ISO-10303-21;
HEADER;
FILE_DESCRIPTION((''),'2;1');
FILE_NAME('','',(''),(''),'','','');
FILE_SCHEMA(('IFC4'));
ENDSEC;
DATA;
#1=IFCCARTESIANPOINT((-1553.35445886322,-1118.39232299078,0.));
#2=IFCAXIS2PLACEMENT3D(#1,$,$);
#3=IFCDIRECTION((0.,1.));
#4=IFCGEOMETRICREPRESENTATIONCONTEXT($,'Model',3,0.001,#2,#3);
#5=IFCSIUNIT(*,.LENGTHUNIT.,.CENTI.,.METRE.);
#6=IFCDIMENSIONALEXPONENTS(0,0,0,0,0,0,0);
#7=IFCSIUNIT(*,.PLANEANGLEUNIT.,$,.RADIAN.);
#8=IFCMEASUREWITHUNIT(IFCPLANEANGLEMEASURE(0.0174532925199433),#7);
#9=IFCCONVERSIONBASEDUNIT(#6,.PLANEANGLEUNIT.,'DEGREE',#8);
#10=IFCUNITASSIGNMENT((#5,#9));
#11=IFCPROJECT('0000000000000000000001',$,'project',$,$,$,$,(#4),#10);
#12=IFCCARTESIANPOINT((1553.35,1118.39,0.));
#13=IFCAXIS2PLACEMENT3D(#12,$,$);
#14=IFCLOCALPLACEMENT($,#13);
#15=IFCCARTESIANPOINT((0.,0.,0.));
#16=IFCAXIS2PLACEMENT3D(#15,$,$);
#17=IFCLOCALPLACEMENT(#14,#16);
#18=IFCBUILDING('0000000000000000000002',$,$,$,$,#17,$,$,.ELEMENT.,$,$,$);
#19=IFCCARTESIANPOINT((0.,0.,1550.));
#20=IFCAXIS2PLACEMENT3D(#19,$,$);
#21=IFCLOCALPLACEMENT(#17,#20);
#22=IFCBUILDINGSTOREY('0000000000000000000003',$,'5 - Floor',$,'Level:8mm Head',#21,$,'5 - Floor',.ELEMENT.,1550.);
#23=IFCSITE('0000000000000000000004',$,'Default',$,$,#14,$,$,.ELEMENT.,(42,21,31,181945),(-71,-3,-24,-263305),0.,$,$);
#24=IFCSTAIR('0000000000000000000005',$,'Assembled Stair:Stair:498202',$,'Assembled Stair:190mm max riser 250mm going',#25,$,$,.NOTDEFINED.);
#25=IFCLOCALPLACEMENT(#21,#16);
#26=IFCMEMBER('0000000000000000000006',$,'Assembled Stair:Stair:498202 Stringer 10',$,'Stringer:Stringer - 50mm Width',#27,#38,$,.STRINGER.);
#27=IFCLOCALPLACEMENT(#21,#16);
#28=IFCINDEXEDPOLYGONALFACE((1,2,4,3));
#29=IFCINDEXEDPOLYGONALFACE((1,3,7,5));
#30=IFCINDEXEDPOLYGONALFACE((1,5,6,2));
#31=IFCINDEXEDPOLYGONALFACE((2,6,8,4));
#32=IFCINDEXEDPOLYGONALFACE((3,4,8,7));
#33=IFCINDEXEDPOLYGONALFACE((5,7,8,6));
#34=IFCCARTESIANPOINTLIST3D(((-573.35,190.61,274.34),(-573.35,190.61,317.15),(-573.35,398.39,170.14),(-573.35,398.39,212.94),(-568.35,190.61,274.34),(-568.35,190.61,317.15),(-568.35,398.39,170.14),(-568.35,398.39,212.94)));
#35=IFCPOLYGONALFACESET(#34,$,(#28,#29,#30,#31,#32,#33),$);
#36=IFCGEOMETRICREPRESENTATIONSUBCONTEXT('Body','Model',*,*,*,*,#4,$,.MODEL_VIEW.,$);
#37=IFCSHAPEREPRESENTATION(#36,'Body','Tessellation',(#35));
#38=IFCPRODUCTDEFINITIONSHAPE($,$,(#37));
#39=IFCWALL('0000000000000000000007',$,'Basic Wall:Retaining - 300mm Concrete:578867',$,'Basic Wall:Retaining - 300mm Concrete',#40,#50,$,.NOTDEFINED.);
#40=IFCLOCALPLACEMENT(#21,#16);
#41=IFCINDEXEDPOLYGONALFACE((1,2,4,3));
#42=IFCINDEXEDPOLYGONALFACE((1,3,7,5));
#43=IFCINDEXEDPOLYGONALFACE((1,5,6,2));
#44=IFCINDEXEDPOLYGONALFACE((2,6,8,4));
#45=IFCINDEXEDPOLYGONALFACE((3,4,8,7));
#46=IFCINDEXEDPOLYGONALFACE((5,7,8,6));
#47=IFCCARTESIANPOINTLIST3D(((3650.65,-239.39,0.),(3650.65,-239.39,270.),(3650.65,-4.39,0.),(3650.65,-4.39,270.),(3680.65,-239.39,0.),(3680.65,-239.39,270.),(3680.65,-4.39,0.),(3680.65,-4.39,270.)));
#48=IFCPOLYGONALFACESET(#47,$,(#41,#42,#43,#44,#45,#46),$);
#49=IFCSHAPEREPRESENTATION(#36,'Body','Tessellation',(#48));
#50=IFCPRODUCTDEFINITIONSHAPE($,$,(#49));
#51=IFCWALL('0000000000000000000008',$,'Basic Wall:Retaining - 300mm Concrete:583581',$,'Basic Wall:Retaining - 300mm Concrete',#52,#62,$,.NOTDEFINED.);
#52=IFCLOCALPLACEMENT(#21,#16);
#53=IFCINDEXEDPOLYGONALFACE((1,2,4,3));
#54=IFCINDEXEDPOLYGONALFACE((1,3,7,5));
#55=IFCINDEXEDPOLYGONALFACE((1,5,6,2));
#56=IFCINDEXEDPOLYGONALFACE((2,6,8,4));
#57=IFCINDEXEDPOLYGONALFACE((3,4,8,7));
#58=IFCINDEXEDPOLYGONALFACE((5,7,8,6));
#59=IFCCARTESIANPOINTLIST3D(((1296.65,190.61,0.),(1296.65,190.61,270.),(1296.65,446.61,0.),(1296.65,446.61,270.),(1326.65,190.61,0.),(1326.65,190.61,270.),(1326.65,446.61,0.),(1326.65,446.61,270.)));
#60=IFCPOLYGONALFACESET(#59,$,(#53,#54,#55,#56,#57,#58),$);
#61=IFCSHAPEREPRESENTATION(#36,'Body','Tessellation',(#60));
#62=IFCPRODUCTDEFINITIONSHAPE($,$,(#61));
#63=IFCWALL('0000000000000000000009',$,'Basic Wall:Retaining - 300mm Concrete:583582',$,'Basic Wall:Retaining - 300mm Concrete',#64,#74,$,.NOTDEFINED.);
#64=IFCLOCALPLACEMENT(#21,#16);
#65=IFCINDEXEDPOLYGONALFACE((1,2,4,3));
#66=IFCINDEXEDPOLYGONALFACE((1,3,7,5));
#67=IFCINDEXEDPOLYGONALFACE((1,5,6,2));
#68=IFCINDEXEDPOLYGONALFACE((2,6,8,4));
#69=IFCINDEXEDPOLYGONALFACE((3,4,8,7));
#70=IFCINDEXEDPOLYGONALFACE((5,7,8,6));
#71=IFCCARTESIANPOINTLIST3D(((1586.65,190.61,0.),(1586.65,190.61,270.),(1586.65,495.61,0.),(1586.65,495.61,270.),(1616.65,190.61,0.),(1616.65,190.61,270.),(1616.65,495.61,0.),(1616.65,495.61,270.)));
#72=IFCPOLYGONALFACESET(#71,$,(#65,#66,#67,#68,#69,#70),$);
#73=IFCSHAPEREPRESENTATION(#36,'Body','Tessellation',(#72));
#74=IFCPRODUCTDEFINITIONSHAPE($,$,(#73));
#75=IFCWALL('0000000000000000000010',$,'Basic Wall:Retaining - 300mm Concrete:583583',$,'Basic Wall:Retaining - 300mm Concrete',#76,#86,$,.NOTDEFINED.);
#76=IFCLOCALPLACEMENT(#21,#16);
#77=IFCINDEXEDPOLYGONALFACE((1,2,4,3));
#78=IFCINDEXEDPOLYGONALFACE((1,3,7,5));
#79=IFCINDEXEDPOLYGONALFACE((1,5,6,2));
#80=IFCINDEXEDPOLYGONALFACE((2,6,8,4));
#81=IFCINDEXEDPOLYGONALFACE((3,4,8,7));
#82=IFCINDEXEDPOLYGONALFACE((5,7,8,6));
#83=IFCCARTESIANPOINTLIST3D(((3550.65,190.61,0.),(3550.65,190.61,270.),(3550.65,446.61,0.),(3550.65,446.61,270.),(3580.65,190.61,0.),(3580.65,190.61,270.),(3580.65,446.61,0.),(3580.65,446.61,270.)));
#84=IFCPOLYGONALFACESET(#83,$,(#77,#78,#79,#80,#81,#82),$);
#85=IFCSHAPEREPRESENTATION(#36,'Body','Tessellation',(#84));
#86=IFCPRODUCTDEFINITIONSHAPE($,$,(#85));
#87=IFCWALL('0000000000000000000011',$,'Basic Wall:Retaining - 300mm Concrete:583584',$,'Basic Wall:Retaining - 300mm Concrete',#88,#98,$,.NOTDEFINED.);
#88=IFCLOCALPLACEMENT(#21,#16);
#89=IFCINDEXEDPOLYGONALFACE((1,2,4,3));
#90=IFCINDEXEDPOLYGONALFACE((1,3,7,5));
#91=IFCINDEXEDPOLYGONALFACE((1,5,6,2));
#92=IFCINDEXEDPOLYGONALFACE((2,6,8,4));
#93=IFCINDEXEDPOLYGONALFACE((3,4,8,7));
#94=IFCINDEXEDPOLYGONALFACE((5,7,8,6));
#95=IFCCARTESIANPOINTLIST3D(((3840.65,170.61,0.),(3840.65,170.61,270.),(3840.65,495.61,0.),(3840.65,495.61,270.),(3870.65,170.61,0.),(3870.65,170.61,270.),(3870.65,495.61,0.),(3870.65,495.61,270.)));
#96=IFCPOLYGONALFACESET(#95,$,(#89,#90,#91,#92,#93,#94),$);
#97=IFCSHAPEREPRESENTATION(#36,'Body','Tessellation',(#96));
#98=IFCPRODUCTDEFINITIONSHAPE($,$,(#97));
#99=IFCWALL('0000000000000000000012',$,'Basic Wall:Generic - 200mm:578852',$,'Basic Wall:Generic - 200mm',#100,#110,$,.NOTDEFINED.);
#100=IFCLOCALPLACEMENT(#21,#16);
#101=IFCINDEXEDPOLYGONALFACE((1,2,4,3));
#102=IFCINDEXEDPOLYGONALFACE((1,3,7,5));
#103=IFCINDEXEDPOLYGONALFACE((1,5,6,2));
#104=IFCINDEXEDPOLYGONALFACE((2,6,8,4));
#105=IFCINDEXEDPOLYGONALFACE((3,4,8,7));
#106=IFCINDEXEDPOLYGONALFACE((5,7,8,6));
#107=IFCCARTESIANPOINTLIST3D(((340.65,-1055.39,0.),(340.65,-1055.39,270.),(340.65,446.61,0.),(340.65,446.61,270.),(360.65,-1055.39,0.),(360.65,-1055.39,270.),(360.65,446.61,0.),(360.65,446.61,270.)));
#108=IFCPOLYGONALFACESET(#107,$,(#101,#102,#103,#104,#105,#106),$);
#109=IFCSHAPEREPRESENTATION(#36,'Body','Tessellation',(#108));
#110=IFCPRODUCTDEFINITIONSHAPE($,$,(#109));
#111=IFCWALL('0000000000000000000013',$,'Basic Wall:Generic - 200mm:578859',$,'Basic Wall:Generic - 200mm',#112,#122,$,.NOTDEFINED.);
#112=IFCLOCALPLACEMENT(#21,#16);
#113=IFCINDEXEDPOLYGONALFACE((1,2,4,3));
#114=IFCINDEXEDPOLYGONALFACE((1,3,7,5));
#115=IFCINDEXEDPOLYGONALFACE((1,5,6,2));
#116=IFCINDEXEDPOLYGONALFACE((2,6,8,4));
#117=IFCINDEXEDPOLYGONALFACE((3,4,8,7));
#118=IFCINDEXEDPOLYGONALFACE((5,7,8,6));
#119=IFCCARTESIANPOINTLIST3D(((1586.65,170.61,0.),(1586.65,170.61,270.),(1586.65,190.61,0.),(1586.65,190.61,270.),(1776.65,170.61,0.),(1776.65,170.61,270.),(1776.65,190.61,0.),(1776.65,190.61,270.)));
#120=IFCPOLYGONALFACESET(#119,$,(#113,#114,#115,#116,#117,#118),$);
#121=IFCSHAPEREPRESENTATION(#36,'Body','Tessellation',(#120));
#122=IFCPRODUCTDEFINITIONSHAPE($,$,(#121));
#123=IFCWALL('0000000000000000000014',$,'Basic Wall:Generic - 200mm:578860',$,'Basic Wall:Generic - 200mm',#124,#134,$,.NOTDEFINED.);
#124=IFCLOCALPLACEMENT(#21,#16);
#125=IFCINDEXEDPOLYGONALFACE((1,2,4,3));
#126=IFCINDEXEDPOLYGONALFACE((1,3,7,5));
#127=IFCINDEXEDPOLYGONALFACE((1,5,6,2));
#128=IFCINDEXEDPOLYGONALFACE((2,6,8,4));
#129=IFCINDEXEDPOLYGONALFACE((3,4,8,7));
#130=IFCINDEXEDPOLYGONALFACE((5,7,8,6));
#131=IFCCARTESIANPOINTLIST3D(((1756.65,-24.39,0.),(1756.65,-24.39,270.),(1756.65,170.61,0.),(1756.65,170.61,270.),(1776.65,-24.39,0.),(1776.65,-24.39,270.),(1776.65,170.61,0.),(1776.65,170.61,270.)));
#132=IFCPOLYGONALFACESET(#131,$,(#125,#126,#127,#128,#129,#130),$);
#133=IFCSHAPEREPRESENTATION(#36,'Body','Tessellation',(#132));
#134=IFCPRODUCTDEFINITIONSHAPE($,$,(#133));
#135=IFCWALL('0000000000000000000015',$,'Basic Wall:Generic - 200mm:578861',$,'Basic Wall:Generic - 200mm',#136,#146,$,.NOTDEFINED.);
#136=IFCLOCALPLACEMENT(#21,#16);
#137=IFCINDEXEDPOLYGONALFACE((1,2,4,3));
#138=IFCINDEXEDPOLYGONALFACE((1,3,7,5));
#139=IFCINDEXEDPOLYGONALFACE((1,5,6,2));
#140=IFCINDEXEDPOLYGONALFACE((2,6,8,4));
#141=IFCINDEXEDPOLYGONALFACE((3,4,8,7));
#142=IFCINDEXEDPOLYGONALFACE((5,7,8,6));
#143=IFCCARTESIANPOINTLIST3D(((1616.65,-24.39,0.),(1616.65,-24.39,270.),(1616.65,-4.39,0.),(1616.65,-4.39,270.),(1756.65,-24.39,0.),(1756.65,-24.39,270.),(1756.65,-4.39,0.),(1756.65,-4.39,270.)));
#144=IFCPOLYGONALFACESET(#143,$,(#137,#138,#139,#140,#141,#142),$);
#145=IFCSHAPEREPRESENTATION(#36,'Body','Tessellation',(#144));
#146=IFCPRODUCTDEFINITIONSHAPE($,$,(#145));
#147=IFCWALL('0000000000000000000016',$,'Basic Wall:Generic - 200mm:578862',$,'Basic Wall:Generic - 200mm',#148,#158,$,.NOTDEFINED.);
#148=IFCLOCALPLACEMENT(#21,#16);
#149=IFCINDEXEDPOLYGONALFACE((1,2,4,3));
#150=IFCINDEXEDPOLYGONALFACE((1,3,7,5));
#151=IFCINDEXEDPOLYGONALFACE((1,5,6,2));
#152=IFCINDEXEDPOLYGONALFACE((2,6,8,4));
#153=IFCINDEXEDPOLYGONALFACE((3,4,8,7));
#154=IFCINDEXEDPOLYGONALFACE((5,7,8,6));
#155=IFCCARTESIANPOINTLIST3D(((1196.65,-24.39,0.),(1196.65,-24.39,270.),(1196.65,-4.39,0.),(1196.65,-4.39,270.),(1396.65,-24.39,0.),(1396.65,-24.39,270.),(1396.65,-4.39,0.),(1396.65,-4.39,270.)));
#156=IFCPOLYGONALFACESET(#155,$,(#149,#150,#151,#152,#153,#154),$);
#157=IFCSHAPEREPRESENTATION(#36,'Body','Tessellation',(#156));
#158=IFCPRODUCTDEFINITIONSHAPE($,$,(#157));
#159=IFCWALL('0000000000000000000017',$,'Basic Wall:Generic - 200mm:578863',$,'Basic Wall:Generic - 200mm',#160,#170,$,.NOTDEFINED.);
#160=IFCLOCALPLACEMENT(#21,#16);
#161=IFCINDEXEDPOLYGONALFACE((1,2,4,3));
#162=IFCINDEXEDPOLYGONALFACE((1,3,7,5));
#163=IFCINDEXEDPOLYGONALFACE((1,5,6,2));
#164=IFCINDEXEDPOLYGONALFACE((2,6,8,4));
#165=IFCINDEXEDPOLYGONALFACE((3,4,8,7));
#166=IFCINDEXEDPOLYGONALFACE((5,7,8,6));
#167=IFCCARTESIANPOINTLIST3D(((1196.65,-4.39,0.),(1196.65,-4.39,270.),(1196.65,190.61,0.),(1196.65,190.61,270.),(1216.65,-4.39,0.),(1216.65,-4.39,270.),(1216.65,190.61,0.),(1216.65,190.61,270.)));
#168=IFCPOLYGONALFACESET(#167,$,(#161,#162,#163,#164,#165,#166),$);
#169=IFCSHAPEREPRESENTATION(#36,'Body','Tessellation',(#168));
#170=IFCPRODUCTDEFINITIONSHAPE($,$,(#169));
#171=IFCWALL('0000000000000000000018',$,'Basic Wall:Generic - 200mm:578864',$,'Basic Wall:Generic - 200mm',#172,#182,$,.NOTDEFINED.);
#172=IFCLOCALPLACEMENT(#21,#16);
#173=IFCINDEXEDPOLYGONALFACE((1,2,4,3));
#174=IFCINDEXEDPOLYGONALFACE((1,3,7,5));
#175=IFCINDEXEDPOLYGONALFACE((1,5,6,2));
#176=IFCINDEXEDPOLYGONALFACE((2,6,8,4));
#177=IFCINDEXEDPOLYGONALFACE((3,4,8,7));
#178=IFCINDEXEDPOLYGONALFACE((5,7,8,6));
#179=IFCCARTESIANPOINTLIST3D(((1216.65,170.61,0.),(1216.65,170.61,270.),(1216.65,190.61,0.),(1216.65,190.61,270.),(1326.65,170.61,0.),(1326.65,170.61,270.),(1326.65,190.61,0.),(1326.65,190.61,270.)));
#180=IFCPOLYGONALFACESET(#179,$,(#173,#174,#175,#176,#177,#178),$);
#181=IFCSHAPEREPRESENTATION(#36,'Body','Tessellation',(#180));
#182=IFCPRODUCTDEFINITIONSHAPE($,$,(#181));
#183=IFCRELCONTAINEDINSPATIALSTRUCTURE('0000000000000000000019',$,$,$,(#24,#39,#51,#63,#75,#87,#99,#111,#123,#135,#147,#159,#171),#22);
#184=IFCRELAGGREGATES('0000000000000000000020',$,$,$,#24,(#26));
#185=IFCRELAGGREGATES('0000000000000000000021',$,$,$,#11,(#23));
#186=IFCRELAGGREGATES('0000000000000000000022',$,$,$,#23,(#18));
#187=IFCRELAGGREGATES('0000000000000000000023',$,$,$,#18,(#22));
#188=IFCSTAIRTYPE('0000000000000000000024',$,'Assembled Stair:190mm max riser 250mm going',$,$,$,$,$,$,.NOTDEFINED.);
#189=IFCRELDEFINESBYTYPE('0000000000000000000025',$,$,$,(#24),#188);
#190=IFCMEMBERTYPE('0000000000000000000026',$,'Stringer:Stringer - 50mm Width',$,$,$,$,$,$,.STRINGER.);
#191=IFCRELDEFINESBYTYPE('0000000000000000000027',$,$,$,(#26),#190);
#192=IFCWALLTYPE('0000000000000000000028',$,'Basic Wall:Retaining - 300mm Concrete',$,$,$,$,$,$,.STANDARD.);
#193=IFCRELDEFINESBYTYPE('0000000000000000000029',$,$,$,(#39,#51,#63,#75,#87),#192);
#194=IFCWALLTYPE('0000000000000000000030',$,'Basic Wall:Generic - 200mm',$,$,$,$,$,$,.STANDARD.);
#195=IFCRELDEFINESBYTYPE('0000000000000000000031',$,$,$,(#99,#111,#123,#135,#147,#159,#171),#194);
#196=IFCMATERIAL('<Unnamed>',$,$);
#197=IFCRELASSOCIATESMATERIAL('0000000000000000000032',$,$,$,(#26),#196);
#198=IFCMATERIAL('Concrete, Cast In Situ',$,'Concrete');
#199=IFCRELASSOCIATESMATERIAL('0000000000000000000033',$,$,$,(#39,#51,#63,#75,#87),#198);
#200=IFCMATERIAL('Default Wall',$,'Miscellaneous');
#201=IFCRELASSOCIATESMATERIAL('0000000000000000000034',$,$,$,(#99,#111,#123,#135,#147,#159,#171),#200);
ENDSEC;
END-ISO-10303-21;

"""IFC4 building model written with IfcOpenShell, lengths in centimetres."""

from ifc_helpers import new_model, entity, si_unit, converted_unit, direction, frame, origin, place, context, subcontext, project, spatial, indexed_curve, outline, extrude, material, type_object, element, aggregate, save


model = new_model("IFC4")

# Units and contexts
model_context = context("Model", 3, precision=0.001, world=frame((-1553.35445886322, -1118.39232299078, 0.0)), true_north=direction((0.0, 1.0)))
body_context = subcontext(model_context, "Body", "Model", "MODEL_VIEW")
ifc_project = project(units=[si_unit("LENGTHUNIT", "METRE", prefix="CENTI"), converted_unit("PLANEANGLEUNIT", "DEGREE", entity("IfcPlaneAngleMeasure", 0.0174532925199433), si_unit("PLANEANGLEUNIT", "RADIAN"), dimensions=[0, 0, 0, 0, 0, 0, 0])], contexts=[model_context])

# Site, building, storey
site_placement = place(None, frame((1553.35, 1118.39, 0.0)))
site = spatial("IfcSite", under=ifc_project, at=site_placement, Name="Default", CompositionType="ELEMENT", RefLatitude=(42, 21, 31, 181945), RefLongitude=(-71, -3, -24, -263305), RefElevation=0.0)
building_placement = place(site_placement, origin())
building = spatial("IfcBuilding", under=site, at=building_placement, CompositionType="ELEMENT")
storey_placement = place(building_placement, frame((0.0, 0.0, 1550.0)))
storey = spatial("IfcBuildingStorey", under=building, at=storey_placement, Name="5 - Floor", ObjectType="Level:8mm Head", LongName="5 - Floor", CompositionType="ELEMENT", Elevation=1550.0)

# Stair, member
stair_type = type_object("IfcStairType", Name="Assembled Stair:190mm max riser 250mm going", PredefinedType="NOTDEFINED")
stair_placement = place(storey_placement, origin())
stair = element("IfcStair", 1, at=stair_placement, inside=storey, type_object=stair_type, Name="Assembled Stair:Stair:498202", ObjectType="Assembled Stair:190mm max riser 250mm going", PredefinedType="NOTDEFINED")
ifc_material_1 = material(Name="<Unnamed>")
member_type = type_object("IfcMemberType", Name="Stringer:Stringer - 50mm Width", PredefinedType="STRINGER")
member_1_placement = place(stair_placement, origin())
member_1 = element("IfcMember", 2, at=member_1_placement, type_object=member_type, material=ifc_material_1, Name="Assembled Stair:Stair:498202 Stringer 10", ObjectType="Stringer:Stringer - 50mm Width", PredefinedType="STRINGER", context=body_context, shape_type="SweptSolid", body=[
    extrude(outline(indexed_curve([(-106.63, -19.13), (125.82, -19.13), (106.63, 19.13), (-125.82, 19.13), (-106.63, -19.13)], self_intersect=False)), frame((-573.35, 294.5, 243.64), z_axis=(1.0, 0.0, 0.0), x_axis=(0.0, -0.893886, 0.448294)), (0.0, 0.0, 1.0), 5.0),
])
aggregate(stair, [member_1])

# Walls
ifc_material_2 = material(Name="Concrete, Cast In Situ", Category="Concrete")
wall_type_1 = type_object("IfcWallType", Name="Basic Wall:Retaining - 300mm Concrete", PredefinedType="STANDARD")
wall_1_placement = place(storey_placement, frame((3665.65, -4.39, 0.0), z_axis=(0.0, 0.0, 1.0), x_axis=(0.0, -1.0, 0.0)))
element("IfcWall", 3, at=wall_1_placement, inside=storey, type_object=wall_type_1, material=ifc_material_2, Name="Basic Wall:Retaining - 300mm Concrete:578867", ObjectType="Basic Wall:Retaining - 300mm Concrete", PredefinedType="NOTDEFINED", context=body_context, shape_type="SweptSolid", body=[
    extrude(outline(indexed_curve([(235.0, 15.0), (0.0, 15.0), (0.0, -15.0), (235.0, -15.0), (235.0, 15.0)], self_intersect=False)), origin(), (0.0, 0.0, 1.0), 270.0),
])
wall_2_placement = place(storey_placement, frame((1311.65, 446.61, 0.0), z_axis=(0.0, 0.0, 1.0), x_axis=(0.0, -1.0, 0.0)))
element("IfcWall", 4, at=wall_2_placement, inside=storey, type_object=wall_type_1, material=ifc_material_2, Name="Basic Wall:Retaining - 300mm Concrete:583581", ObjectType="Basic Wall:Retaining - 300mm Concrete", PredefinedType="NOTDEFINED", context=body_context, shape_type="SweptSolid", body=[
    extrude(outline(indexed_curve([(256.0, 15.0), (0.0, 15.0), (0.0, -15.0), (256.0, -15.0), (256.0, 15.0)], self_intersect=False)), origin(), (0.0, 0.0, 1.0), 270.0),
])
wall_3_placement = place(storey_placement, frame((1601.65, 495.61, 0.0), z_axis=(0.0, 0.0, 1.0), x_axis=(0.0, -1.0, 0.0)))
element("IfcWall", 5, at=wall_3_placement, inside=storey, type_object=wall_type_1, material=ifc_material_2, Name="Basic Wall:Retaining - 300mm Concrete:583582", ObjectType="Basic Wall:Retaining - 300mm Concrete", PredefinedType="NOTDEFINED", context=body_context, shape_type="SweptSolid", body=[
    extrude(outline(indexed_curve([(305.0, 15.0), (0.0, 15.0), (0.0, -15.0), (305.0, -15.0), (305.0, 15.0)], self_intersect=False)), origin(), (0.0, 0.0, 1.0), 270.0),
])
wall_4_placement = place(storey_placement, frame((3565.65, 446.61, 0.0), z_axis=(0.0, 0.0, 1.0), x_axis=(0.0, -1.0, 0.0)))
element("IfcWall", 6, at=wall_4_placement, inside=storey, type_object=wall_type_1, material=ifc_material_2, Name="Basic Wall:Retaining - 300mm Concrete:583583", ObjectType="Basic Wall:Retaining - 300mm Concrete", PredefinedType="NOTDEFINED", context=body_context, shape_type="SweptSolid", body=[
    extrude(outline(indexed_curve([(256.0, 15.0), (0.0, 15.0), (0.0, -15.0), (256.0, -15.0), (256.0, 15.0)], self_intersect=False)), origin(), (0.0, 0.0, 1.0), 270.0),
])
wall_5_placement = place(storey_placement, frame((3855.65, 495.61, 0.0), z_axis=(0.0, 0.0, 1.0), x_axis=(0.0, -1.0, 0.0)))
element("IfcWall", 7, at=wall_5_placement, inside=storey, type_object=wall_type_1, material=ifc_material_2, Name="Basic Wall:Retaining - 300mm Concrete:583584", ObjectType="Basic Wall:Retaining - 300mm Concrete", PredefinedType="NOTDEFINED", context=body_context, shape_type="SweptSolid", body=[
    extrude(outline(indexed_curve([(325.0, 15.0), (0.0, 15.0), (0.0, -15.0), (325.0, -15.0), (325.0, 15.0)], self_intersect=False)), origin(), (0.0, 0.0, 1.0), 270.0),
])
ifc_material_3 = material(Name="Default Wall", Category="Miscellaneous")
wall_type_2 = type_object("IfcWallType", Name="Basic Wall:Generic - 200mm", PredefinedType="STANDARD")
wall_6_placement = place(storey_placement, frame((350.65, 446.61, 0.0), z_axis=(0.0, 0.0, 1.0), x_axis=(0.0, -1.0, 0.0)))
element("IfcWall", 8, at=wall_6_placement, inside=storey, type_object=wall_type_2, material=ifc_material_3, Name="Basic Wall:Generic - 200mm:578852", ObjectType="Basic Wall:Generic - 200mm", PredefinedType="NOTDEFINED", context=body_context, shape_type="SweptSolid", body=[
    extrude(outline(indexed_curve([(1502.0, 10.0), (0.0, 10.0), (0.0, -10.0), (1502.0, -10.0), (1502.0, 10.0)], self_intersect=False)), origin(), (0.0, 0.0, 1.0), 270.0),
])
wall_7_placement = place(storey_placement, frame((1586.65, 180.61, 0.0)))
element("IfcWall", 9, at=wall_7_placement, inside=storey, type_object=wall_type_2, material=ifc_material_3, Name="Basic Wall:Generic - 200mm:578859", ObjectType="Basic Wall:Generic - 200mm", PredefinedType="NOTDEFINED", context=body_context, shape_type="SweptSolid", body=[
    extrude(outline(indexed_curve([(190.0, 10.0), (0.0, 10.0), (0.0, -10.0), (190.0, -10.0), (190.0, 10.0)], self_intersect=False)), origin(), (0.0, 0.0, 1.0), 270.0),
])
wall_8_placement = place(storey_placement, frame((1766.65, 170.61, 0.0), z_axis=(0.0, 0.0, 1.0), x_axis=(0.0, -1.0, 0.0)))
element("IfcWall", 10, at=wall_8_placement, inside=storey, type_object=wall_type_2, material=ifc_material_3, Name="Basic Wall:Generic - 200mm:578860", ObjectType="Basic Wall:Generic - 200mm", PredefinedType="NOTDEFINED", context=body_context, shape_type="SweptSolid", body=[
    extrude(outline(indexed_curve([(195.0, 10.0), (0.0, 10.0), (0.0, -10.0), (195.0, -10.0), (195.0, 10.0)], self_intersect=False)), origin(), (0.0, 0.0, 1.0), 270.0),
])
wall_9_placement = place(storey_placement, frame((1616.65, -14.39, 0.0)))
element("IfcWall", 11, at=wall_9_placement, inside=storey, type_object=wall_type_2, material=ifc_material_3, Name="Basic Wall:Generic - 200mm:578861", ObjectType="Basic Wall:Generic - 200mm", PredefinedType="NOTDEFINED", context=body_context, shape_type="SweptSolid", body=[
    extrude(outline(indexed_curve([(140.0, 10.0), (0.0, 10.0), (0.0, -10.0), (140.0, -10.0), (140.0, 10.0)], self_intersect=False)), origin(), (0.0, 0.0, 1.0), 270.0),
])
wall_10_placement = place(storey_placement, frame((1396.65, -14.39, 0.0), z_axis=(0.0, 0.0, 1.0), x_axis=(-1.0, 0.0, 0.0)))
element("IfcWall", 12, at=wall_10_placement, inside=storey, type_object=wall_type_2, material=ifc_material_3, Name="Basic Wall:Generic - 200mm:578862", ObjectType="Basic Wall:Generic - 200mm", PredefinedType="NOTDEFINED", context=body_context, shape_type="SweptSolid", body=[
    extrude(outline(indexed_curve([(200.0, 10.0), (0.0, 10.0), (0.0, -10.0), (200.0, -10.0), (200.0, 10.0)], self_intersect=False)), origin(), (0.0, 0.0, 1.0), 270.0),
])
wall_11_placement = place(storey_placement, frame((1206.65, -4.39, 0.0), z_axis=(0.0, 0.0, 1.0), x_axis=(0.0, 1.0, 0.0)))
element("IfcWall", 13, at=wall_11_placement, inside=storey, type_object=wall_type_2, material=ifc_material_3, Name="Basic Wall:Generic - 200mm:578863", ObjectType="Basic Wall:Generic - 200mm", PredefinedType="NOTDEFINED", context=body_context, shape_type="SweptSolid", body=[
    extrude(outline(indexed_curve([(195.0, 10.0), (0.0, 10.0), (0.0, -10.0), (195.0, -10.0), (195.0, 10.0)], self_intersect=False)), origin(), (0.0, 0.0, 1.0), 270.0),
])
wall_12_placement = place(storey_placement, frame((1216.65, 180.61, 0.0)))
element("IfcWall", 14, at=wall_12_placement, inside=storey, type_object=wall_type_2, material=ifc_material_3, Name="Basic Wall:Generic - 200mm:578864", ObjectType="Basic Wall:Generic - 200mm", PredefinedType="NOTDEFINED", context=body_context, shape_type="SweptSolid", body=[
    extrude(outline(indexed_curve([(110.0, 10.0), (0.0, 10.0), (0.0, -10.0), (110.0, -10.0), (110.0, 10.0)], self_intersect=False)), origin(), (0.0, 0.0, 1.0), 270.0),
])

save(model, "model.ifc")
